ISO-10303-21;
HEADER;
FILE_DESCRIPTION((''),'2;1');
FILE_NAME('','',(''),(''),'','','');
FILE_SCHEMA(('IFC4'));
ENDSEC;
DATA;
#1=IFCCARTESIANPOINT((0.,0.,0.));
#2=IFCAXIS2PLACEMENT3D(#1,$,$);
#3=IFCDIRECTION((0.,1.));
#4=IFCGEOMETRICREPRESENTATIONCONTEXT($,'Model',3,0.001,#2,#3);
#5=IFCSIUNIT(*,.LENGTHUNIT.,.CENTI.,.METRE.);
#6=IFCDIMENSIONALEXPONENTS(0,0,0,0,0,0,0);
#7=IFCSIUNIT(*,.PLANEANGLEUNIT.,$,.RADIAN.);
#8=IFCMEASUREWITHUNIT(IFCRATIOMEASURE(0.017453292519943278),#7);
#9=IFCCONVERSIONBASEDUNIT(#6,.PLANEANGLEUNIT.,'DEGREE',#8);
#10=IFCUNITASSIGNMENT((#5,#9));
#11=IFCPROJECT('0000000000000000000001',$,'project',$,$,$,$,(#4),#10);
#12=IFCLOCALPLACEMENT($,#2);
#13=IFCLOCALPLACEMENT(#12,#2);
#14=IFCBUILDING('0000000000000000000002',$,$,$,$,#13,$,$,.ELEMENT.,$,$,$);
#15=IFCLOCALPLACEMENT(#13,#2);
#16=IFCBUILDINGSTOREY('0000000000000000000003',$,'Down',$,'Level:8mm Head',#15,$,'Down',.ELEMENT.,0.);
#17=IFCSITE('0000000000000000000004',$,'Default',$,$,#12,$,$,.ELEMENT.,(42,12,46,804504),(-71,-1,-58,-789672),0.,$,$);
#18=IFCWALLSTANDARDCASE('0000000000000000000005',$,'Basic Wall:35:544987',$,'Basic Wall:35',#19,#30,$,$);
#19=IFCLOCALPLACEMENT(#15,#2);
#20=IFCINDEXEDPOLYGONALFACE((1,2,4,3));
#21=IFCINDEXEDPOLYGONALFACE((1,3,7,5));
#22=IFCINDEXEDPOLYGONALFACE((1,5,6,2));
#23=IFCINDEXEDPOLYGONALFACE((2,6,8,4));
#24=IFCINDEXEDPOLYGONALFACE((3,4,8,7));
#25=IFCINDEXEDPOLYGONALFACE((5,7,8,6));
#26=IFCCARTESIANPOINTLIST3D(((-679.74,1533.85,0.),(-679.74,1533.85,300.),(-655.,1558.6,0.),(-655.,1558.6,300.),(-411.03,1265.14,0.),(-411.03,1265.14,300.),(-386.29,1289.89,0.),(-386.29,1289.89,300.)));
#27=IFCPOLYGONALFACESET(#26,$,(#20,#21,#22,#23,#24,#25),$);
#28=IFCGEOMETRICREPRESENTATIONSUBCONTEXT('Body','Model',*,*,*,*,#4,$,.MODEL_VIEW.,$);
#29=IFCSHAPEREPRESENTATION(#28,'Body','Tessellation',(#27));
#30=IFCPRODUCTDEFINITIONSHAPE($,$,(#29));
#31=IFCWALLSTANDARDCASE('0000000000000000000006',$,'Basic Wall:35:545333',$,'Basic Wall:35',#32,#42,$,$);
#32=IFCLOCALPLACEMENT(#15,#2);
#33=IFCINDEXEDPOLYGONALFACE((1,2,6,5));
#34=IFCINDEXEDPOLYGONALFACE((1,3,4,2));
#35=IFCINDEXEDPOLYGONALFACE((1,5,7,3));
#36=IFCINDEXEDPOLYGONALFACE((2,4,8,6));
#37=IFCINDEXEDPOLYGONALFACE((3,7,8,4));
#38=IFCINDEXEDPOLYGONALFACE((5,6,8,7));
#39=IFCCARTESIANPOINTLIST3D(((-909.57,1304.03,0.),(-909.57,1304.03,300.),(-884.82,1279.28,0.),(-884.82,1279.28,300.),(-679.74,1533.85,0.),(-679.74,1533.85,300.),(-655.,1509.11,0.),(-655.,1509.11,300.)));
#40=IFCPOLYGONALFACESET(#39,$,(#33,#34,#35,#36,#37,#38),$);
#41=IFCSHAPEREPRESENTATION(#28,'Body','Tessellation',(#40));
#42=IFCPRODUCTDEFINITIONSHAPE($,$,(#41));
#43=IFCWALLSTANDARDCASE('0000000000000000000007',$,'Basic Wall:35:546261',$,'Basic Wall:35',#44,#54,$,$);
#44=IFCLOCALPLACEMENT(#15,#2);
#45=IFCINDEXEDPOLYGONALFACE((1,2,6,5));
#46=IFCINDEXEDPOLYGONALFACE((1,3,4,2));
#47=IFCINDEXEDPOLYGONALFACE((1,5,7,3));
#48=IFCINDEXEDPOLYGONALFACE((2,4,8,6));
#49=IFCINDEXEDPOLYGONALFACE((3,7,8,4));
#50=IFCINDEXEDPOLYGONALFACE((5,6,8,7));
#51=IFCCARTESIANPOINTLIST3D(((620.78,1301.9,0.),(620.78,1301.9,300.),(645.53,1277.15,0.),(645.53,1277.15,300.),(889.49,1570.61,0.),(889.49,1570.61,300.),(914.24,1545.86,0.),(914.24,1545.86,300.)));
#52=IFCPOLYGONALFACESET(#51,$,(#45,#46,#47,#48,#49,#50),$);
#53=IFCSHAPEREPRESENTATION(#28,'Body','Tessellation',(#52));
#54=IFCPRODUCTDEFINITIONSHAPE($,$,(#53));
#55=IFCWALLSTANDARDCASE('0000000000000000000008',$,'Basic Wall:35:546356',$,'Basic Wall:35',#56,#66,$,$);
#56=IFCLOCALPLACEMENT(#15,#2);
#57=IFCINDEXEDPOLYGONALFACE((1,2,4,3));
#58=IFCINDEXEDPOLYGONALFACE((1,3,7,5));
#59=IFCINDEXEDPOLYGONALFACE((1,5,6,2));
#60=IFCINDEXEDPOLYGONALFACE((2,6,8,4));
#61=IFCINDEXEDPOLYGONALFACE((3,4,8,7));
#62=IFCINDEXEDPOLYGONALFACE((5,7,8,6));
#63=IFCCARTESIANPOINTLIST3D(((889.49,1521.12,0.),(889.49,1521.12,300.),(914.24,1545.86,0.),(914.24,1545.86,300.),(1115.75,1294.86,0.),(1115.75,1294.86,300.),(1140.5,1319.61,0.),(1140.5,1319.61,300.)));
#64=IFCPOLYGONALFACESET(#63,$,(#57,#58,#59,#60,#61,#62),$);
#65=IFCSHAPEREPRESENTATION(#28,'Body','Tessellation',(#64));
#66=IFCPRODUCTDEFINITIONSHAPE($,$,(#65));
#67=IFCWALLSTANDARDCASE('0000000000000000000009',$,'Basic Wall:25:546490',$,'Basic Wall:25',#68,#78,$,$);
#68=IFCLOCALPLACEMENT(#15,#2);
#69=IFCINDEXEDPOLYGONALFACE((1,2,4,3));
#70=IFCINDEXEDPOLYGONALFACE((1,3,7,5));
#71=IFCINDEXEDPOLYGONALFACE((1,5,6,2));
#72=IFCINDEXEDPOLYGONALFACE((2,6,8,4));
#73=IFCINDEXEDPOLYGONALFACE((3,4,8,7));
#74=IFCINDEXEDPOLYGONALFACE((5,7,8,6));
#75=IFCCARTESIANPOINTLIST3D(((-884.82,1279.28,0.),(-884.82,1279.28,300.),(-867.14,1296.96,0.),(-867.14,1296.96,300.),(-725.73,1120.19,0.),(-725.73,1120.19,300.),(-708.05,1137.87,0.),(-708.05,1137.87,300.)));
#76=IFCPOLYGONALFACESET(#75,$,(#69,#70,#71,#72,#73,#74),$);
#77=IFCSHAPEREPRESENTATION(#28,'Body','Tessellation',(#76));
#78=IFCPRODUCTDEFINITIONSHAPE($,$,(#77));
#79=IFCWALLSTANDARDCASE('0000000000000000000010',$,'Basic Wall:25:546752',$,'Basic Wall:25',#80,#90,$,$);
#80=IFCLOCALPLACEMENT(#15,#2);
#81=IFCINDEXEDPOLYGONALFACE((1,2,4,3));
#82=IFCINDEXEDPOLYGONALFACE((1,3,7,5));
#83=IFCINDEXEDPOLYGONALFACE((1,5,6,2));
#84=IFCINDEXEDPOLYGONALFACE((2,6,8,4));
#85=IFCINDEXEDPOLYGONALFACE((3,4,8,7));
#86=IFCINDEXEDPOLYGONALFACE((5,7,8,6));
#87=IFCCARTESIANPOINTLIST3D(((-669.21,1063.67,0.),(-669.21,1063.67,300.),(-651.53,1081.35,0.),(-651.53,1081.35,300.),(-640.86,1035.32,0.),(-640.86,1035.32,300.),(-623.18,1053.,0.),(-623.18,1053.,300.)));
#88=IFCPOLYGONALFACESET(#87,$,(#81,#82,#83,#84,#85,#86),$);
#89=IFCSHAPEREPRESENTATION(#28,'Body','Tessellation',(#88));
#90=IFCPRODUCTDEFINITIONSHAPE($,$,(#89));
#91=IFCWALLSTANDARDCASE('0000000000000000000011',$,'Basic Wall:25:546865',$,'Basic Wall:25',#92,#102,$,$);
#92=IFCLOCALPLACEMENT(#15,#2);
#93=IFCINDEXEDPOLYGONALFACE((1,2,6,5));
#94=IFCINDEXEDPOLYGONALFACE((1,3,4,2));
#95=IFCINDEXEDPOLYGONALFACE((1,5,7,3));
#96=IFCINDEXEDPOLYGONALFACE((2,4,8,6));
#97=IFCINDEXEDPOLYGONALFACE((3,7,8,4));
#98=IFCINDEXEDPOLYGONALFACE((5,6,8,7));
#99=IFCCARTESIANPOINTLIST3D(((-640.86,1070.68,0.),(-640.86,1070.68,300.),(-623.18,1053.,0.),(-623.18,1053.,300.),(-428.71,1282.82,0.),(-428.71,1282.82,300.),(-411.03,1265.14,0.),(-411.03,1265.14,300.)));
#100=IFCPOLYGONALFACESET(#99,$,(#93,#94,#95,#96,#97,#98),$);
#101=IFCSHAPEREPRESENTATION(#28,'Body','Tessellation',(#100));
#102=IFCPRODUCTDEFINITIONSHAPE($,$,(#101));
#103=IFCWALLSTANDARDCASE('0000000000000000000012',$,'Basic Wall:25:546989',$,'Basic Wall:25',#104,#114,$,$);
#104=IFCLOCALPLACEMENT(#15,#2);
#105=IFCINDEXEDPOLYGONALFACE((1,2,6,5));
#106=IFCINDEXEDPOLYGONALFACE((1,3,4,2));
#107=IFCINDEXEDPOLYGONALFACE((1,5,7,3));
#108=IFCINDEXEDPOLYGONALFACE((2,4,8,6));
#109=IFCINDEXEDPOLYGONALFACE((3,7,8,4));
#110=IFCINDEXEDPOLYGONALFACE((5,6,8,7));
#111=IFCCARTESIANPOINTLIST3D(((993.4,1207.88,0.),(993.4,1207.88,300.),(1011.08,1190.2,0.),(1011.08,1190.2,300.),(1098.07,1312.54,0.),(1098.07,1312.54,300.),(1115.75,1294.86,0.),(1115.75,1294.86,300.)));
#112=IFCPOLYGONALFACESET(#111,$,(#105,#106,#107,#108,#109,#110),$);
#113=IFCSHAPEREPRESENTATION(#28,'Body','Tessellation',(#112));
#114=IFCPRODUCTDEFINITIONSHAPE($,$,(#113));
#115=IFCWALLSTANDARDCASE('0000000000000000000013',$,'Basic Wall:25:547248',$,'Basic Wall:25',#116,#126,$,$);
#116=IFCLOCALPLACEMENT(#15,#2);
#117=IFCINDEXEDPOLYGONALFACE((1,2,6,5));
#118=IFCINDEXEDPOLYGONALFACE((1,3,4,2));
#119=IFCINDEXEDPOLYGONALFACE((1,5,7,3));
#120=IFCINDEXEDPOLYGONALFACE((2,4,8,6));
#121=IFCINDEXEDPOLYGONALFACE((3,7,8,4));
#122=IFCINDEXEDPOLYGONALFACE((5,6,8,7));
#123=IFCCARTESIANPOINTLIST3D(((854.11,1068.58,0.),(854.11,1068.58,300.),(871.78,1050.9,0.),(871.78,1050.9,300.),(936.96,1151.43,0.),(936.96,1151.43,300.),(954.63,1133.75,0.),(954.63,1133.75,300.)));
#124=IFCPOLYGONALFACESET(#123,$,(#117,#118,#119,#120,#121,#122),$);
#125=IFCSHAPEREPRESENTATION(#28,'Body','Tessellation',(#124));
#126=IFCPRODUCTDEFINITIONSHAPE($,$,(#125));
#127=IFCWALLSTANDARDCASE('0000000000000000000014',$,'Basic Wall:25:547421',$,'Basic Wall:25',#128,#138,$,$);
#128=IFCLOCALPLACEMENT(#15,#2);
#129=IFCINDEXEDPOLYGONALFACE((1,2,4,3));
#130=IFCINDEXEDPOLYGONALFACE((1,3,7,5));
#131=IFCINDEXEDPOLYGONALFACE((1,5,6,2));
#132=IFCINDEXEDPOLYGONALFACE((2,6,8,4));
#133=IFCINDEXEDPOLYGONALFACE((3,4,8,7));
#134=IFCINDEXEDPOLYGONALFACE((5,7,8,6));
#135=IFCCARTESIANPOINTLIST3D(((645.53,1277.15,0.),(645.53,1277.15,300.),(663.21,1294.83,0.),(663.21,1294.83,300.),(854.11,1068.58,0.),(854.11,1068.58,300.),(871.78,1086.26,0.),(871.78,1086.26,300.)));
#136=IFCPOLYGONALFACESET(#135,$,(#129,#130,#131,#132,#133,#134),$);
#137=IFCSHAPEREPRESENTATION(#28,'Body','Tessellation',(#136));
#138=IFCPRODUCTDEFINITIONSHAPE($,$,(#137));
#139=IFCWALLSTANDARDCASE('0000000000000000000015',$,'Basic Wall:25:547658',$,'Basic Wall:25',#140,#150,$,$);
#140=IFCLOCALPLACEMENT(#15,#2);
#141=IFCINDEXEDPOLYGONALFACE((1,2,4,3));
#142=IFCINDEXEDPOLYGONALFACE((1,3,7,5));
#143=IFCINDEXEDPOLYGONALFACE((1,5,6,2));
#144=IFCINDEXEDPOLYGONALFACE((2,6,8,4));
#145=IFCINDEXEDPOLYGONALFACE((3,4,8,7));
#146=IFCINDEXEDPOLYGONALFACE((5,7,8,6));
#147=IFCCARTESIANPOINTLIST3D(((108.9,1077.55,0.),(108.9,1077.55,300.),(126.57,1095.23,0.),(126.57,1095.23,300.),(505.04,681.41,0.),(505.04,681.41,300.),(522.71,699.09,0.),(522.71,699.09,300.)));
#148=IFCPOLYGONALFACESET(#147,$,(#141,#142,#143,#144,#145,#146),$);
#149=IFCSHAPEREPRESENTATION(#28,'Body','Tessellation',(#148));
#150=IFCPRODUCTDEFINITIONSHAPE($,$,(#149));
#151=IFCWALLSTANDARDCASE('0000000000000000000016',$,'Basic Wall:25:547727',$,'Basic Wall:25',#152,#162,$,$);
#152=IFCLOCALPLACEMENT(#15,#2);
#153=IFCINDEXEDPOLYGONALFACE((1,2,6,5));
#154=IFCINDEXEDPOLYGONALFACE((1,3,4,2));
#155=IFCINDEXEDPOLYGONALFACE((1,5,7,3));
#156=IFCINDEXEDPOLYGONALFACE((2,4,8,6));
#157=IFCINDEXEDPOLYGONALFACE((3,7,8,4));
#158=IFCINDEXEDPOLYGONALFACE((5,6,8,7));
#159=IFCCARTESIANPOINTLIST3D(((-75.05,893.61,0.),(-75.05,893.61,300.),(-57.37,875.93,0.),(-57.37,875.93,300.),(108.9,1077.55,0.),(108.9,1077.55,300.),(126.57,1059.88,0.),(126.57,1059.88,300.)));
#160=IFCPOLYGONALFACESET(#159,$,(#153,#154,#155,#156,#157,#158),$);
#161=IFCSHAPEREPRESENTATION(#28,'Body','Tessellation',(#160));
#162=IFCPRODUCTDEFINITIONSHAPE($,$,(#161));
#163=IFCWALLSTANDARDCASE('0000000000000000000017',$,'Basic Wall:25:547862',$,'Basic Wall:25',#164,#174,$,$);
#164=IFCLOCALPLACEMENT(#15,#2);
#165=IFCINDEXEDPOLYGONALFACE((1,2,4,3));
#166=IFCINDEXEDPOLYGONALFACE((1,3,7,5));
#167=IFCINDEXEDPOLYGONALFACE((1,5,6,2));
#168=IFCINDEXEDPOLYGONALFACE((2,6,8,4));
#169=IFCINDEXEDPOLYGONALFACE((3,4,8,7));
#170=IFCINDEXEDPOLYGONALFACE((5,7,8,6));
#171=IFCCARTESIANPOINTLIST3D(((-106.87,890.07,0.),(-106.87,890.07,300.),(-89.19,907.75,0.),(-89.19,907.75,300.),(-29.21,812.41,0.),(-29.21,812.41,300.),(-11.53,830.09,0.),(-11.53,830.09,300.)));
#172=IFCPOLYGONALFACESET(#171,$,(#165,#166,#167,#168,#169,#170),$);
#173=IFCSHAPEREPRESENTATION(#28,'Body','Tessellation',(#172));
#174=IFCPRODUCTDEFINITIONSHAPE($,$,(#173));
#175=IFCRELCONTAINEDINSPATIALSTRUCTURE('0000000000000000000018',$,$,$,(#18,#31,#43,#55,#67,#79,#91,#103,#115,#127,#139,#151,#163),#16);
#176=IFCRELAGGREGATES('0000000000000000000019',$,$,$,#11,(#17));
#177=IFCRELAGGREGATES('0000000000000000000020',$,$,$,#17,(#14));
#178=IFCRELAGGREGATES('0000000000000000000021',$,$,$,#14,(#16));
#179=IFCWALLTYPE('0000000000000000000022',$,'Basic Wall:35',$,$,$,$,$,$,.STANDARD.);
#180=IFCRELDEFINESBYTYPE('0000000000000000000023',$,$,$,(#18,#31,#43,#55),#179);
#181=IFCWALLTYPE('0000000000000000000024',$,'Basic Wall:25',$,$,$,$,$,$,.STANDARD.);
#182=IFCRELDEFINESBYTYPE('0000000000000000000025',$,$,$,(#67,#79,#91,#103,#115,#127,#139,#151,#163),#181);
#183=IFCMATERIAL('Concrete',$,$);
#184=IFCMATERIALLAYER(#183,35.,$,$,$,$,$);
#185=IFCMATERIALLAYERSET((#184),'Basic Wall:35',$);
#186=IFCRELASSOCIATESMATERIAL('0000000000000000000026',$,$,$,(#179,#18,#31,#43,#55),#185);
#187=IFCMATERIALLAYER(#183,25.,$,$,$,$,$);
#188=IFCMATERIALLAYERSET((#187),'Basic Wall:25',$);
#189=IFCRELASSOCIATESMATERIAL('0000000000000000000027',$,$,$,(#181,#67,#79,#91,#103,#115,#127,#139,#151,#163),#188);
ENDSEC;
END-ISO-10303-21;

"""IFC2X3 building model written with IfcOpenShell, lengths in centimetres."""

from ifc_helpers import new_model, entity, si_unit, converted_unit, direction, frame, frame_2d, origin, place, context, subcontext, project, spatial, rectangle, extrude, material, layer, layer_set, layer_usage, type_object, element, save


model = new_model("IFC2X3")

# Units and contexts
model_context = context("Model", 3, precision=0.001, world=origin(), true_north=direction((0.0, 1.0)))
body_context = subcontext(model_context, "Body", "Model", "MODEL_VIEW")
ifc_project = project(units=[si_unit("LENGTHUNIT", "METRE", prefix="CENTI"), converted_unit("PLANEANGLEUNIT", "DEGREE", entity("IfcRatioMeasure", 0.017453292519943278), si_unit("PLANEANGLEUNIT", "RADIAN"), dimensions=[0, 0, 0, 0, 0, 0, 0])], contexts=[model_context])

# Site, building, storey
site_placement = place(None, origin())
site = spatial("IfcSite", under=ifc_project, at=site_placement, Name="Default", CompositionType="ELEMENT", RefLatitude=(42, 12, 46, 804504), RefLongitude=(-71, -1, -58, -789672), RefElevation=0.0)
building_placement = place(site_placement, origin())
building = spatial("IfcBuilding", under=site, at=building_placement, CompositionType="ELEMENT")
storey_placement = place(building_placement, origin())
storey = spatial("IfcBuildingStorey", under=building, at=storey_placement, Name="Down", ObjectType="Level:8mm Head", LongName="Down", CompositionType="ELEMENT", Elevation=0.0)

# Walls
ifc_material = material(Name="Concrete")
ifc_layer_1 = layer(ifc_material, 35.0)
ifc_layer_set_1 = layer_set([ifc_layer_1], Name="Basic Wall:35")
ifc_layer_usage_1 = layer_usage(ifc_layer_set_1, "AXIS2", "NEGATIVE", 17.5)
wall_type_1 = type_object("IfcWallType", Name="Basic Wall:35", PredefinedType="STANDARD", material=ifc_layer_set_1)
wall_1_placement = place(storey_placement, frame((-667.37, 1546.23, 0.0), z_axis=(0.0, 0.0, 1.0), x_axis=(0.707107, -0.707107, 0.0)))
element("IfcWallStandardCase", 1, at=wall_1_placement, inside=storey, type_object=wall_type_1, material=ifc_layer_usage_1, Name="Basic Wall:35:544987", ObjectType="Basic Wall:35", context=body_context, shape_type="SweptSolid", body=[
    extrude(rectangle(XDim=380.01, YDim=35.0, at=frame_2d((190.01, 0.0), x_axis=(-1.0, 0.0))), origin(), (0.0, 0.0, 1.0), 300.0),
])
ifc_layer_usage_2 = layer_usage(ifc_layer_set_1, "AXIS2", "POSITIVE", -17.5)
wall_2_placement = place(storey_placement, frame((-667.37, 1521.48, 0.0), z_axis=(0.0, 0.0, 1.0), x_axis=(-0.707107, -0.707107, 0.0)))
element("IfcWallStandardCase", 2, at=wall_2_placement, inside=storey, type_object=wall_type_1, material=ifc_layer_usage_2, Name="Basic Wall:35:545333", ObjectType="Basic Wall:35", context=body_context, shape_type="SweptSolid", body=[
    extrude(rectangle(XDim=325.02, YDim=35.0, at=frame_2d((162.51, 0.0), x_axis=(-1.0, 0.0))), origin(), (0.0, 0.0, 1.0), 300.0),
])
ifc_layer_usage_3 = layer_usage(ifc_layer_set_1, "AXIS2", "NEGATIVE", 17.5)
wall_3_placement = place(storey_placement, frame((633.16, 1289.53, 0.0), z_axis=(0.0, 0.0, 1.0), x_axis=(0.707107, 0.707107, 0.0)))
element("IfcWallStandardCase", 3, at=wall_3_placement, inside=storey, type_object=wall_type_1, material=ifc_layer_usage_3, Name="Basic Wall:35:546261", ObjectType="Basic Wall:35", context=body_context, shape_type="SweptSolid", body=[
    extrude(rectangle(XDim=380.01, YDim=35.0, at=frame_2d((190.01, 0.0), x_axis=(-1.0, 0.0))), origin(), (0.0, 0.0, 1.0), 300.0),
])
ifc_layer_usage_4 = layer_usage(ifc_layer_set_1, "AXIS2", "NEGATIVE", 17.5)
wall_4_placement = place(storey_placement, frame((901.87, 1533.49, 0.0), z_axis=(0.0, 0.0, 1.0), x_axis=(0.707107, -0.707107, 0.0)))
element("IfcWallStandardCase", 4, at=wall_4_placement, inside=storey, type_object=wall_type_1, material=ifc_layer_usage_4, Name="Basic Wall:35:546356", ObjectType="Basic Wall:35", context=body_context, shape_type="SweptSolid", body=[
    extrude(rectangle(XDim=319.97, YDim=35.0, at=frame_2d((159.98, 0.0), x_axis=(-1.0, 0.0))), origin(), (0.0, 0.0, 1.0), 300.0),
])
ifc_layer_2 = layer(ifc_material, 25.0)
ifc_layer_set_2 = layer_set([ifc_layer_2], Name="Basic Wall:25")
ifc_layer_usage_5 = layer_usage(ifc_layer_set_2, "AXIS2", "POSITIVE", -12.5)
wall_type_2 = type_object("IfcWallType", Name="Basic Wall:25", PredefinedType="STANDARD", material=ifc_layer_set_2)
wall_5_placement = place(storey_placement, frame((-875.98, 1288.12, 0.0), z_axis=(0.0, 0.0, 1.0), x_axis=(0.707107, -0.707107, 0.0)))
element("IfcWallStandardCase", 5, at=wall_5_placement, inside=storey, type_object=wall_type_2, material=ifc_layer_usage_5, Name="Basic Wall:25:546490", ObjectType="Basic Wall:25", context=body_context, shape_type="SweptSolid", body=[
    extrude(rectangle(XDim=224.99, YDim=25.0, at=frame_2d((112.5, 0.0), x_axis=(-1.0, 0.0))), origin(), (0.0, 0.0, 1.0), 300.0),
])
ifc_layer_usage_6 = layer_usage(ifc_layer_set_2, "AXIS2", "NEGATIVE", 12.5)
wall_6_placement = place(storey_placement, frame((-632.02, 1044.16, 0.0), z_axis=(0.0, 0.0, 1.0), x_axis=(-0.707107, 0.707107, 0.0)))
element("IfcWallStandardCase", 6, at=wall_6_placement, inside=storey, type_object=wall_type_2, material=ifc_layer_usage_6, Name="Basic Wall:25:546752", ObjectType="Basic Wall:25", context=body_context, shape_type="SweptSolid", body=[
    extrude(rectangle(XDim=40.09, YDim=25.0, at=frame_2d((20.05, 0.0), x_axis=(-1.0, 0.0))), origin(), (0.0, 0.0, 1.0), 300.0),
])
ifc_layer_usage_7 = layer_usage(ifc_layer_set_2, "AXIS2", "POSITIVE", -12.5)
wall_7_placement = place(storey_placement, frame((-632.02, 1061.84, 0.0), z_axis=(0.0, 0.0, 1.0), x_axis=(0.707107, 0.707107, 0.0)))
element("IfcWallStandardCase", 7, at=wall_7_placement, inside=storey, type_object=wall_type_2, material=ifc_layer_usage_7, Name="Basic Wall:25:546865", ObjectType="Basic Wall:25", context=body_context, shape_type="SweptSolid", body=[
    extrude(rectangle(XDim=300.02, YDim=25.0, at=frame_2d((150.01, 0.0), x_axis=(-1.0, 0.0))), origin(), (0.0, 0.0, 1.0), 300.0),
])
ifc_layer_usage_8 = layer_usage(ifc_layer_set_2, "AXIS2", "NEGATIVE", 12.5)
wall_8_placement = place(storey_placement, frame((1106.91, 1303.7, 0.0), z_axis=(0.0, 0.0, 1.0), x_axis=(-0.707107, -0.707107, 0.0)))
element("IfcWallStandardCase", 8, at=wall_8_placement, inside=storey, type_object=wall_type_2, material=ifc_layer_usage_8, Name="Basic Wall:25:546989", ObjectType="Basic Wall:25", context=body_context, shape_type="SweptSolid", body=[
    extrude(rectangle(XDim=148.02, YDim=25.0, at=frame_2d((74.01, 0.0), x_axis=(-1.0, 0.0))), origin(), (0.0, 0.0, 1.0), 300.0),
])
ifc_layer_usage_9 = layer_usage(ifc_layer_set_2, "AXIS2", "POSITIVE", -12.5)
wall_9_placement = place(storey_placement, frame((862.95, 1059.74, 0.0), z_axis=(0.0, 0.0, 1.0), x_axis=(0.707107, 0.707107, 0.0)))
element("IfcWallStandardCase", 9, at=wall_9_placement, inside=storey, type_object=wall_type_2, material=ifc_layer_usage_9, Name="Basic Wall:25:547248", ObjectType="Basic Wall:25", context=body_context, shape_type="SweptSolid", body=[
    extrude(rectangle(XDim=117.17, YDim=25.0, at=frame_2d((58.58, 0.0), x_axis=(-1.0, 0.0))), origin(), (0.0, 0.0, 1.0), 300.0),
])
ifc_layer_usage_10 = layer_usage(ifc_layer_set_2, "AXIS2", "NEGATIVE", 12.5)
wall_10_placement = place(storey_placement, frame((862.95, 1077.42, 0.0), z_axis=(0.0, 0.0, 1.0), x_axis=(-0.707107, 0.707107, 0.0)))
element("IfcWallStandardCase", 10, at=wall_10_placement, inside=storey, type_object=wall_type_2, material=ifc_layer_usage_10, Name="Basic Wall:25:547421", ObjectType="Basic Wall:25", context=body_context, shape_type="SweptSolid", body=[
    extrude(rectangle(XDim=294.97, YDim=25.0, at=frame_2d((147.48, 0.0), x_axis=(-1.0, 0.0))), origin(), (0.0, 0.0, 1.0), 300.0),
])
ifc_layer_usage_11 = layer_usage(ifc_layer_set_2, "AXIS2", "POSITIVE", -12.5)
wall_11_placement = place(storey_placement, frame((513.87, 690.25, 0.0), z_axis=(0.0, 0.0, 1.0), x_axis=(-0.707107, 0.707107, 0.0)))
element("IfcWallStandardCase", 11, at=wall_11_placement, inside=storey, type_object=wall_type_2, material=ifc_layer_usage_11, Name="Basic Wall:25:547658", ObjectType="Basic Wall:25", context=body_context, shape_type="SweptSolid", body=[
    extrude(rectangle(XDim=560.23, YDim=25.0, at=frame_2d((280.11, 0.0), x_axis=(-1.0, 0.0))), origin(), (0.0, 0.0, 1.0), 300.0),
])
ifc_layer_usage_12 = layer_usage(ifc_layer_set_2, "AXIS2", "POSITIVE", -12.5)
wall_12_placement = place(storey_placement, frame((117.73, 1068.71, 0.0), z_axis=(0.0, 0.0, 1.0), x_axis=(-0.707107, -0.707107, 0.0)))
element("IfcWallStandardCase", 12, at=wall_12_placement, inside=storey, type_object=wall_type_2, material=ifc_layer_usage_12, Name="Basic Wall:25:547727", ObjectType="Basic Wall:25", context=body_context, shape_type="SweptSolid", body=[
    extrude(rectangle(XDim=260.14, YDim=25.0, at=frame_2d((130.07, 0.0), x_axis=(-1.0, 0.0))), origin(), (0.0, 0.0, 1.0), 300.0),
])
ifc_layer_usage_13 = layer_usage(ifc_layer_set_2, "AXIS2", "NEGATIVE", 12.5)
wall_13_placement = place(storey_placement, frame((-20.37, 821.25, 0.0), z_axis=(0.0, 0.0, 1.0), x_axis=(-0.707107, 0.707107, 0.0)))
element("IfcWallStandardCase", 13, at=wall_13_placement, inside=storey, type_object=wall_type_2, material=ifc_layer_usage_13, Name="Basic Wall:25:547862", ObjectType="Basic Wall:25", context=body_context, shape_type="SweptSolid", body=[
    extrude(rectangle(XDim=109.83, YDim=25.0, at=frame_2d((54.91, 0.0), x_axis=(-1.0, 0.0))), origin(), (0.0, 0.0, 1.0), 300.0),
])

save(model, "model.ifc")
